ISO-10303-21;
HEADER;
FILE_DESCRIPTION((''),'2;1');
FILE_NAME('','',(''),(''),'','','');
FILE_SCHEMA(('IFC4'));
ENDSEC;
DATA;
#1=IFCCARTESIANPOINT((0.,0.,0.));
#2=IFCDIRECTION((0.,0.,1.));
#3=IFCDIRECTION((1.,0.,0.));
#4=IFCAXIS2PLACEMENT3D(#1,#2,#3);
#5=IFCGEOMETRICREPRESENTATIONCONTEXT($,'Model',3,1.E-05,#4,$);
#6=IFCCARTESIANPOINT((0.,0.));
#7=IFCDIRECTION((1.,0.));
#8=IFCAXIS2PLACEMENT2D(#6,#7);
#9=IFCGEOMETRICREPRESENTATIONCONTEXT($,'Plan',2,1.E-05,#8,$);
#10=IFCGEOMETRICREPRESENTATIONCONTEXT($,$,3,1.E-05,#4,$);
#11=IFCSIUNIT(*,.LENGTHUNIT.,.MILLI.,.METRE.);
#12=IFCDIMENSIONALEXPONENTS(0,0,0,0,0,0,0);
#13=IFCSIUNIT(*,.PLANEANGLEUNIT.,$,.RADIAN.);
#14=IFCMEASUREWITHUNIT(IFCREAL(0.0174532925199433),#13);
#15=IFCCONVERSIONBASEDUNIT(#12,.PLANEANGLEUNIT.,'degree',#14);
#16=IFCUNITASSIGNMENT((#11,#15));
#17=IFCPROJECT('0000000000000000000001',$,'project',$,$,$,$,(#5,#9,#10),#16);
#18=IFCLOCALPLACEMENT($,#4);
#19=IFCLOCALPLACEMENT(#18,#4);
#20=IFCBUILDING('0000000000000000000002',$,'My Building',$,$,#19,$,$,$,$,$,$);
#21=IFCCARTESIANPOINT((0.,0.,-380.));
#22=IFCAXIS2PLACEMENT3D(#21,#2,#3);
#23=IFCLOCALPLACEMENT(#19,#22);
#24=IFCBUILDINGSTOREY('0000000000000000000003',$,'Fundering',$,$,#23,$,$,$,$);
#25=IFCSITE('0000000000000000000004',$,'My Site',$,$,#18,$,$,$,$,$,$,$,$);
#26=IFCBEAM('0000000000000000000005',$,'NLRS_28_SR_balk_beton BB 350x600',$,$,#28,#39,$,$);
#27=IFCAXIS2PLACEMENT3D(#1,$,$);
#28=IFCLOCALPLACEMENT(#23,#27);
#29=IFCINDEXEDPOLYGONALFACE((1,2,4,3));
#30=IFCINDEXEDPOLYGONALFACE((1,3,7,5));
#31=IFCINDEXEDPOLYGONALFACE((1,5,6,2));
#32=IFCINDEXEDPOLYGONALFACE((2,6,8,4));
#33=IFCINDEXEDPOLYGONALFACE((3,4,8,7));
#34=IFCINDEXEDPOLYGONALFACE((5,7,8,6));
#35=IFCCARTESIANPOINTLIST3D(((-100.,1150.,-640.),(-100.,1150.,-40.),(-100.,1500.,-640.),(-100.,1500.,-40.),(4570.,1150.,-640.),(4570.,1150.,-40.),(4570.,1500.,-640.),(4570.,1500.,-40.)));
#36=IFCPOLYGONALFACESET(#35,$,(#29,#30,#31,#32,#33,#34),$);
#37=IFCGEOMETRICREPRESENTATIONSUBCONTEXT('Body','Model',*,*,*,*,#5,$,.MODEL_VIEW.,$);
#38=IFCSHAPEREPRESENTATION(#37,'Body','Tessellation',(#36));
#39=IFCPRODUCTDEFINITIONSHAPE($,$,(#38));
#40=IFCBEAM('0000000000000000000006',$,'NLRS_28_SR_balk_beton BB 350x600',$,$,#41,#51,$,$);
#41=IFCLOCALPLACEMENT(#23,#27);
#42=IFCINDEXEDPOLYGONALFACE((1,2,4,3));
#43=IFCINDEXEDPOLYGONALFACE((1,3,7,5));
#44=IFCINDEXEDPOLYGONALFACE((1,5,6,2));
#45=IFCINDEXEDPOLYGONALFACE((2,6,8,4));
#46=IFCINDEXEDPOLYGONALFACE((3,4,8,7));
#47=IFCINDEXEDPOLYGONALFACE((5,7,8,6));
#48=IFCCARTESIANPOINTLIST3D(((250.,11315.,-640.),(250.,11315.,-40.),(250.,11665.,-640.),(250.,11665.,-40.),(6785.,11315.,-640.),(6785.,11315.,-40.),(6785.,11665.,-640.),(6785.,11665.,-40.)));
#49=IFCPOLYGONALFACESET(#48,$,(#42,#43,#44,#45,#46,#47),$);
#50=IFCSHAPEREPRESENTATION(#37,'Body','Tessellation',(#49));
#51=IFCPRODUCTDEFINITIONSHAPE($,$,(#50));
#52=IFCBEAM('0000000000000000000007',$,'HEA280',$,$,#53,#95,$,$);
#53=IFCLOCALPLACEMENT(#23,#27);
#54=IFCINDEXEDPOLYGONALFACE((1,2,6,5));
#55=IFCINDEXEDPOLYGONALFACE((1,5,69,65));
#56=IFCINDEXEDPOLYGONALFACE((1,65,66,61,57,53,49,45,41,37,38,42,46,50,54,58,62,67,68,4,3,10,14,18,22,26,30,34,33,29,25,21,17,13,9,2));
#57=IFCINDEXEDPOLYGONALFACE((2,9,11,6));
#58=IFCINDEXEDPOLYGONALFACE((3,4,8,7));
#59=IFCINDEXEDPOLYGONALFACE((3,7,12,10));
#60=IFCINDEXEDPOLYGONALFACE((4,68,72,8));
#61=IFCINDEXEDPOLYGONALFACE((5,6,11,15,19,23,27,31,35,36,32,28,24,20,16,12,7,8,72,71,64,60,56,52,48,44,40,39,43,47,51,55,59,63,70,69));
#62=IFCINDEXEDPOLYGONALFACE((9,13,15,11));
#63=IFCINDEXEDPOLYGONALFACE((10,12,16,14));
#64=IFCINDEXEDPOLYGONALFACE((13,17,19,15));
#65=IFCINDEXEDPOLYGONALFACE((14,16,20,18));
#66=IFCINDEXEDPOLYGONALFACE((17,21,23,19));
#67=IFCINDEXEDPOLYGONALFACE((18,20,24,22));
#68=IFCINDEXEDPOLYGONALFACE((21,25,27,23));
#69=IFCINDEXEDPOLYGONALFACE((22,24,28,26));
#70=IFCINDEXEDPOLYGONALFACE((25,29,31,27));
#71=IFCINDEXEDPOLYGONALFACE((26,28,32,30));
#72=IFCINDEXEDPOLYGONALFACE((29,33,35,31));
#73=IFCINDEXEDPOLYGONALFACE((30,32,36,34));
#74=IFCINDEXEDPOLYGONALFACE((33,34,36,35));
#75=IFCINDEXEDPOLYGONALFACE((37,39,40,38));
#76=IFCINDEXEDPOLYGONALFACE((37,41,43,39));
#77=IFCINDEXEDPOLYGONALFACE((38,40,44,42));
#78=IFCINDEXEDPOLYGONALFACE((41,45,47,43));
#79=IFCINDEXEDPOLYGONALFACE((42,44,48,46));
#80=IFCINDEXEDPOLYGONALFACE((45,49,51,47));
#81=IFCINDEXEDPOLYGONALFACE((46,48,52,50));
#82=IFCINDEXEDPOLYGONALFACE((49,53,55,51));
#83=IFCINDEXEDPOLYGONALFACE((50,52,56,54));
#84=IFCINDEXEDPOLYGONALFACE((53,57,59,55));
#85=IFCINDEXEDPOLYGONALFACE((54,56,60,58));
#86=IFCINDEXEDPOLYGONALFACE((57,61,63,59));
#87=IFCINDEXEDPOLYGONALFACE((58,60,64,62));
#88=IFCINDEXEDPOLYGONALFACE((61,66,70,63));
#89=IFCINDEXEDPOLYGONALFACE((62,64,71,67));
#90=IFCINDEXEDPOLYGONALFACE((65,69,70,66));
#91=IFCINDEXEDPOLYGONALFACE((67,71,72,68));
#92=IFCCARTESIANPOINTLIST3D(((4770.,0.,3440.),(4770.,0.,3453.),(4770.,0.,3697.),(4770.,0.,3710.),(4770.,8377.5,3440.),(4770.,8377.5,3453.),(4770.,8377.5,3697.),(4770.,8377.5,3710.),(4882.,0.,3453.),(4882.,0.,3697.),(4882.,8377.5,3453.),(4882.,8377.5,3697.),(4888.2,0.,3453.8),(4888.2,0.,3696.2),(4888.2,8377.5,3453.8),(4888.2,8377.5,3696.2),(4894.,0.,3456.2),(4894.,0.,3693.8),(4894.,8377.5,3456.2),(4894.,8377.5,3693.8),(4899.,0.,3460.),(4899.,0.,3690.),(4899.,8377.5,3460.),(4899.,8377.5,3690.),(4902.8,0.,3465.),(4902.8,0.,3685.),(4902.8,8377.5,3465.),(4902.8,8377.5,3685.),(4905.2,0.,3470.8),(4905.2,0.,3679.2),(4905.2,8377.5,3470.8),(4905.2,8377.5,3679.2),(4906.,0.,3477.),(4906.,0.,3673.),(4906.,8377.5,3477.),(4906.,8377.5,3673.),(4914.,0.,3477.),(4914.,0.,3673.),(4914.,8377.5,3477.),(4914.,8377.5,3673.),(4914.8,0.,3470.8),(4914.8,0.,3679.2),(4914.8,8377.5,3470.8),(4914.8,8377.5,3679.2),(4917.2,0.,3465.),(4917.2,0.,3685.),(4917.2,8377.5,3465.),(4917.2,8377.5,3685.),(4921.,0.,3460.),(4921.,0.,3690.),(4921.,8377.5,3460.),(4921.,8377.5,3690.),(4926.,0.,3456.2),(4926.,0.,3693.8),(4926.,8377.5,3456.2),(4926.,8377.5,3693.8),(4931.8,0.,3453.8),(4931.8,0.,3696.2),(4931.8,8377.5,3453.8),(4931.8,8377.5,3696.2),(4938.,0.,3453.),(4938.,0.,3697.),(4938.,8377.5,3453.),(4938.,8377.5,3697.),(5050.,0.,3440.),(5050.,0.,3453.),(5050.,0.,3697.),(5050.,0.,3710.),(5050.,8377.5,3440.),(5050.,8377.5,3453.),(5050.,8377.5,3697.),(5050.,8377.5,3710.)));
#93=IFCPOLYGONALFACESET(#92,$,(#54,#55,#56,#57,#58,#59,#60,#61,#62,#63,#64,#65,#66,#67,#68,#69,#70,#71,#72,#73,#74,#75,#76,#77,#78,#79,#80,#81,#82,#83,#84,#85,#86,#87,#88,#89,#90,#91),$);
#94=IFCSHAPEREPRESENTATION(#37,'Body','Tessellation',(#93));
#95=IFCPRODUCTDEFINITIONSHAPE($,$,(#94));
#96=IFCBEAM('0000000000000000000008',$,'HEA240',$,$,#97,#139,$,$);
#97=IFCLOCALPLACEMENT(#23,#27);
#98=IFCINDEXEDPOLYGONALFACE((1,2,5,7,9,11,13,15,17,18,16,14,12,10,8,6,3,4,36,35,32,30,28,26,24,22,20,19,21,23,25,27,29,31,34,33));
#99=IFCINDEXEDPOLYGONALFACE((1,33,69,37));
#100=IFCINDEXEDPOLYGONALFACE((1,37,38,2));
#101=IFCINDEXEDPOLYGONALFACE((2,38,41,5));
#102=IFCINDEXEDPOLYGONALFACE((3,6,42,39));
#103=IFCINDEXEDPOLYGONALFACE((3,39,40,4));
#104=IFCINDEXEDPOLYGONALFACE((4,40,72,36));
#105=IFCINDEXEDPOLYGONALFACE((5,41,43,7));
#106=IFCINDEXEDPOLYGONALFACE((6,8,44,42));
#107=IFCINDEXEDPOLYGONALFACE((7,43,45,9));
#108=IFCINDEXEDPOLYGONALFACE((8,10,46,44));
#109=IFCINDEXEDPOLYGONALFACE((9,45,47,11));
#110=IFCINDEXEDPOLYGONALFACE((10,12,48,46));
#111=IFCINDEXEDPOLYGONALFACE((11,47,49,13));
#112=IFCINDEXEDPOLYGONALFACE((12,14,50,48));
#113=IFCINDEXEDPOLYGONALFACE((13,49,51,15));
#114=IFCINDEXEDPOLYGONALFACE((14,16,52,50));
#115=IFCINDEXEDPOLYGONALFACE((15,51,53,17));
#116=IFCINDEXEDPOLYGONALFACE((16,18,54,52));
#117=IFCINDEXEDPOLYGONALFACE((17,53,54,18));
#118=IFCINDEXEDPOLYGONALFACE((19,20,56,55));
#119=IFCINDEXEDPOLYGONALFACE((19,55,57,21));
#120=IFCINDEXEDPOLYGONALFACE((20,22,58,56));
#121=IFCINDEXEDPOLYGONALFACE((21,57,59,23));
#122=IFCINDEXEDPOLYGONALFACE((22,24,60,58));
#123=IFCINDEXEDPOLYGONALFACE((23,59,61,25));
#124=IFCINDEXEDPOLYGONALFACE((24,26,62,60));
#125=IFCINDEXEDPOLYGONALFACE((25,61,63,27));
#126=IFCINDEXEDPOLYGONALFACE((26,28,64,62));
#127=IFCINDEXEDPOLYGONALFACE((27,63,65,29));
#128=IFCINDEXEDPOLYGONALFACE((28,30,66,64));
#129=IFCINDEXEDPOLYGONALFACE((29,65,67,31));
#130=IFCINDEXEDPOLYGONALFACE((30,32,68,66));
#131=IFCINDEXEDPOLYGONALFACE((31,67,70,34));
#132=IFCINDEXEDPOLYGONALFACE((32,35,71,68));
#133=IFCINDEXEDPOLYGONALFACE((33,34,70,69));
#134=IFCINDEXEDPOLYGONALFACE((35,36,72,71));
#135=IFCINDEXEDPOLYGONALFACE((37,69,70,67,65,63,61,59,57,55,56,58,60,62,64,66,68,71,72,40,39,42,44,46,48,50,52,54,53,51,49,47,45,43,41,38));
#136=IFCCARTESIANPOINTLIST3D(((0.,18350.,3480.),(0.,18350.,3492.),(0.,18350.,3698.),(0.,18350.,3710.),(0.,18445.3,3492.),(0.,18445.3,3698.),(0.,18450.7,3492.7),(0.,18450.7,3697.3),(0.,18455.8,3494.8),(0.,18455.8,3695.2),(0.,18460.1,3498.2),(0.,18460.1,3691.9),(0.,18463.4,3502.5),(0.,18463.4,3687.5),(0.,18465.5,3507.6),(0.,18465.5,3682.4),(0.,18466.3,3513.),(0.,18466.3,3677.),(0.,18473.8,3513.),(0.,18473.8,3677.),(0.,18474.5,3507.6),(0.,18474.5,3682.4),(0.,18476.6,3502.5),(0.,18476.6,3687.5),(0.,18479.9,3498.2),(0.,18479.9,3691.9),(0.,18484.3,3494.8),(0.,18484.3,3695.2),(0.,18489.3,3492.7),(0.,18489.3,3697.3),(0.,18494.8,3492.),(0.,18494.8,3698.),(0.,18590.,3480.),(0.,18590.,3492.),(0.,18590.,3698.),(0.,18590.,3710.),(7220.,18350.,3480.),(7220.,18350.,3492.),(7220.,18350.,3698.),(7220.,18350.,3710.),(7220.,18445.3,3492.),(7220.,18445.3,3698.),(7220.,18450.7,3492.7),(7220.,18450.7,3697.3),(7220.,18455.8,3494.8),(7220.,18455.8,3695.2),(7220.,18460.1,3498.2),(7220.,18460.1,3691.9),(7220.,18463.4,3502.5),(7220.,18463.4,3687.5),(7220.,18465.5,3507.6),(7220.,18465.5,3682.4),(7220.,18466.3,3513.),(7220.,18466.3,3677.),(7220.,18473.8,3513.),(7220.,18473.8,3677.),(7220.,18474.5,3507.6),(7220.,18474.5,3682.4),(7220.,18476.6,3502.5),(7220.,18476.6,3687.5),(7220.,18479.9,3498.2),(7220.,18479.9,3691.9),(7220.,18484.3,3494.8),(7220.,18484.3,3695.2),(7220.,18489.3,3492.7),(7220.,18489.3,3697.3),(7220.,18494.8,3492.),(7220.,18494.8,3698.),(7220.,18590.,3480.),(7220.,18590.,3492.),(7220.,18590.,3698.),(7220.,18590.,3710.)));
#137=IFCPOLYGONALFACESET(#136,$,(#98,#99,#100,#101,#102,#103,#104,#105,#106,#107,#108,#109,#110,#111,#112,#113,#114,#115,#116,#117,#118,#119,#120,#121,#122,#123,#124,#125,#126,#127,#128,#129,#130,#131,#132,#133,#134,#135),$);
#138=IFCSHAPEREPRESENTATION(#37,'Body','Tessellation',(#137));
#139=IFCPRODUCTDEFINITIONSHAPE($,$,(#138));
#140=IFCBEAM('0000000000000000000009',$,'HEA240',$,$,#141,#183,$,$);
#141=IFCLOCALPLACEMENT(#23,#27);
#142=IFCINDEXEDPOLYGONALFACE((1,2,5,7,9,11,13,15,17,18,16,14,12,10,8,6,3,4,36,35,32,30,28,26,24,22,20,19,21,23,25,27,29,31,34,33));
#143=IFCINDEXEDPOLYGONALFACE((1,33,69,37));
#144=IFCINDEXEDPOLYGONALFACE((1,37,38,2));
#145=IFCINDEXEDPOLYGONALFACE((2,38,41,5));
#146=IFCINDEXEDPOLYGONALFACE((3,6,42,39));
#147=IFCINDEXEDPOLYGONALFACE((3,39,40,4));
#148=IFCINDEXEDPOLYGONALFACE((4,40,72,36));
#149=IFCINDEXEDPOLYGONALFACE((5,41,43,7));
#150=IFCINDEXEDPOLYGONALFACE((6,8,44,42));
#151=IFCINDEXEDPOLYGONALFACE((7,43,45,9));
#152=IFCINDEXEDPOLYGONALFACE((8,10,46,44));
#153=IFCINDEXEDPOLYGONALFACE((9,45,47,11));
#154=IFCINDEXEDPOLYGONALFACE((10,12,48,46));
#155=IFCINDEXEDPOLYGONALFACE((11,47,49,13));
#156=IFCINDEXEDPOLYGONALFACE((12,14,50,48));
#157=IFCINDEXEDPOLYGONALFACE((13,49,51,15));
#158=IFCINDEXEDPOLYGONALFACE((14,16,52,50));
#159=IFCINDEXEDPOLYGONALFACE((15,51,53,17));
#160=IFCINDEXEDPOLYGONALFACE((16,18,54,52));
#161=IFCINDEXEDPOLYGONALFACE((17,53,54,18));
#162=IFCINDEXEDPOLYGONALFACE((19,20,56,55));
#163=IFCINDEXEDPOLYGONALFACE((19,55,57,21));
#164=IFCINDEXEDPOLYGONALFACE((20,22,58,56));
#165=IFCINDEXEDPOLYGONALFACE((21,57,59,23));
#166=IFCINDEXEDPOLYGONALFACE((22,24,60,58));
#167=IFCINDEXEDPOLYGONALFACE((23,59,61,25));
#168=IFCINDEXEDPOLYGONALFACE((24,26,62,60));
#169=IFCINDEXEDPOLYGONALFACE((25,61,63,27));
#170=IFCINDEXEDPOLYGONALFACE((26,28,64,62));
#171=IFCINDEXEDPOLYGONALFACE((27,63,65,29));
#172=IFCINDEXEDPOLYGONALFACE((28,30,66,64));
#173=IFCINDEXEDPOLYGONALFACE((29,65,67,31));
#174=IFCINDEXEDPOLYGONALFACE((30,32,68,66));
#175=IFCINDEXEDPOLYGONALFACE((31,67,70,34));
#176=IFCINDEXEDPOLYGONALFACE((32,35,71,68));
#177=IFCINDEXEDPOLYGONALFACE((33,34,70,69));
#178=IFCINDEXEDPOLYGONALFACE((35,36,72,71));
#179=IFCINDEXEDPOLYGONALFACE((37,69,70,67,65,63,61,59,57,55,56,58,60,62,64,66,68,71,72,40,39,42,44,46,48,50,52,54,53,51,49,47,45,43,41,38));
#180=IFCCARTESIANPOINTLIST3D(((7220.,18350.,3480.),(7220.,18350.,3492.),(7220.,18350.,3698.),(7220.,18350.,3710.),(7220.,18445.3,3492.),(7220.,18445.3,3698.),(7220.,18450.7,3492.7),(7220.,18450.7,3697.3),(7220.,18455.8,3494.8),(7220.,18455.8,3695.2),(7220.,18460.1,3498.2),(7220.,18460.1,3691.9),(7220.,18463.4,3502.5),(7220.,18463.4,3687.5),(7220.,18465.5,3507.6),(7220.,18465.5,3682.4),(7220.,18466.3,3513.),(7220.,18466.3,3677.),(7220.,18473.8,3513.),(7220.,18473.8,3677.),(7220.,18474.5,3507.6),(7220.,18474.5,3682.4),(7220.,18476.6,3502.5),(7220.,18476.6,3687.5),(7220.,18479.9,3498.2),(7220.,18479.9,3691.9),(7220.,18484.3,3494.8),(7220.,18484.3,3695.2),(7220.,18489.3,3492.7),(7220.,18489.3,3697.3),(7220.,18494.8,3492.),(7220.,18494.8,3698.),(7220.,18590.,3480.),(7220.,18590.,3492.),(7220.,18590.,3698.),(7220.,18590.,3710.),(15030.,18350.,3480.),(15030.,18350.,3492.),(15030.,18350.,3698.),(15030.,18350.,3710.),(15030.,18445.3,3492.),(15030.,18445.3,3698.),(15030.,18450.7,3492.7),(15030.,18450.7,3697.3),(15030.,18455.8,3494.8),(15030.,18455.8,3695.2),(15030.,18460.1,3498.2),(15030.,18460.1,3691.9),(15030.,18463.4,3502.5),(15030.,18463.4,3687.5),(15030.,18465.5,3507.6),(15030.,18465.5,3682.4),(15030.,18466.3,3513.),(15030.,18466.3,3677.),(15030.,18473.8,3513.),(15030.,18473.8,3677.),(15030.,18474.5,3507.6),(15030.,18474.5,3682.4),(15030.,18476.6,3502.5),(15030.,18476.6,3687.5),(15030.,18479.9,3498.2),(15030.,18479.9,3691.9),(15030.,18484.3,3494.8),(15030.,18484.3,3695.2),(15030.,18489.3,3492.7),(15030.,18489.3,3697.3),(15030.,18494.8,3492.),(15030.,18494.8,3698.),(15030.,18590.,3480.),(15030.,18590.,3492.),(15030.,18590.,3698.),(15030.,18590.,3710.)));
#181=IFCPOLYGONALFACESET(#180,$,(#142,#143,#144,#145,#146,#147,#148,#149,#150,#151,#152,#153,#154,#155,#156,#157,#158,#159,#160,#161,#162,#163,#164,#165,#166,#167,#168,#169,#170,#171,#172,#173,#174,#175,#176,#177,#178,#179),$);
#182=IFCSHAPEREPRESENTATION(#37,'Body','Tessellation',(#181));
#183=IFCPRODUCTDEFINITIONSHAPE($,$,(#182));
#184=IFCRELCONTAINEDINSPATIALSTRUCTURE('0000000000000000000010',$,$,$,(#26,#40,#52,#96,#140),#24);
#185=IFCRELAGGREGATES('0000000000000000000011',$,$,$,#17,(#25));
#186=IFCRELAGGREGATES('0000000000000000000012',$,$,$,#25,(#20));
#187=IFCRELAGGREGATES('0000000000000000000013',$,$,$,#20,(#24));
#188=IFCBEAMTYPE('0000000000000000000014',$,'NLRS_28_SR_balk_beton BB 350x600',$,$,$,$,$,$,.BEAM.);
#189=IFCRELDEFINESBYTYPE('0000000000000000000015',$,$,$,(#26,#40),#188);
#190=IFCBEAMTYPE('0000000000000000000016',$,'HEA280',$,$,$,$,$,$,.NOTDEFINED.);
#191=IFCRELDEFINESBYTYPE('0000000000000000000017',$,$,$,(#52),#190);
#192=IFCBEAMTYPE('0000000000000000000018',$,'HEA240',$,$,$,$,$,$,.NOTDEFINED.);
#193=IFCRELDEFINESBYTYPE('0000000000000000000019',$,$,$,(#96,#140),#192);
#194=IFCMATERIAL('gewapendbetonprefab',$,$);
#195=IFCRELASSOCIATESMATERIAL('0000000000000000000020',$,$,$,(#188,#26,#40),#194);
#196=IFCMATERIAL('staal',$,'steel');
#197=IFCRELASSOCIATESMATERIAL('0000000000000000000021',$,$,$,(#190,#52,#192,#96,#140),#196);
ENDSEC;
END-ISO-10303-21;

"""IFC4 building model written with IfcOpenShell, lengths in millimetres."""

from ifc_helpers import new_model, entity, si_unit, converted_unit, frame, origin_with_axes, origin_2d_with_axis, place, context, subcontext, project, spatial, rectangle, i_section, extrude, material, material_profile, profile_set, profile_usage, type_object, element, save


model = new_model("IFC4")

# Units and contexts
model_context = context("Model", 3, precision=1e-05, world=origin_with_axes())
plan_context = context("Plan", 2, precision=1e-05, world=origin_2d_with_axis())
context_of_model = context(None, 3, precision=1e-05, world=origin_with_axes())
body_context = subcontext(model_context, "Body", "Model", "MODEL_VIEW")
ifc_project = project(units=[si_unit("LENGTHUNIT", "METRE", prefix="MILLI"), converted_unit("PLANEANGLEUNIT", "degree", entity("IfcReal", 0.0174532925199433), si_unit("PLANEANGLEUNIT", "RADIAN"), dimensions=[0, 0, 0, 0, 0, 0, 0])], contexts=[model_context, plan_context, context_of_model])

# Site, building, storey
site_placement = place(None, origin_with_axes())
site = spatial("IfcSite", under=ifc_project, at=site_placement, Name="My Site")
building_placement = place(site_placement, origin_with_axes())
building = spatial("IfcBuilding", under=site, at=building_placement, Name="My Building")
storey_placement = place(building_placement, frame((0.0, 0.0, -380.0), z_axis=(0.0, 0.0, 1.0), x_axis=(1.0, 0.0, 0.0)))
storey = spatial("IfcBuildingStorey", under=building, at=storey_placement, Name="Fundering")

# Shared definitions
ifc_material_1 = material(Name="staal", Category="steel")

# Beams
ifc_material_2 = material(Name="gewapendbetonprefab")
ifc_material_profile_1 = material_profile(ifc_material_2, rectangle(XDim=350.0, YDim=600.0))
ifc_profile_set_1 = profile_set([ifc_material_profile_1], Name="NLRS_28_SR_balk_beton BB 350x600")
beam_type_1 = type_object("IfcBeamType", Name="NLRS_28_SR_balk_beton BB 350x600", PredefinedType="BEAM", material=ifc_profile_set_1)
ifc_profile_usage_1 = profile_usage(ifc_profile_set_1, cardinal=8)
beam_1_placement = place(storey_placement, frame((4570.0, 1325.0, -40.0), z_axis=(-1.0, 0.0, 0.0), x_axis=(0.0, -1.0, 0.0)))
element("IfcBeam", 1, at=beam_1_placement, inside=storey, type_object=beam_type_1, material=ifc_profile_usage_1, Name="NLRS_28_SR_balk_beton BB 350x600", context=body_context, shape_type="SweptSolid", body=[
    extrude(rectangle(XDim=350.0, YDim=600.0), frame((0.0, -300.0, 0.0), z_axis=(0.0, 0.0, 1.0), x_axis=(1.0, 0.0, 0.0)), (0.0, 0.0, 1.0), 4670.0),
])
ifc_profile_usage_2 = profile_usage(ifc_profile_set_1, cardinal=8)
beam_2_placement = place(storey_placement, frame((6785.0, 11490.0, -40.0), z_axis=(-1.0, 0.0, 0.0), x_axis=(0.0, -1.0, 0.0)))
element("IfcBeam", 2, at=beam_2_placement, inside=storey, type_object=beam_type_1, material=ifc_profile_usage_2, Name="NLRS_28_SR_balk_beton BB 350x600", context=body_context, shape_type="SweptSolid", body=[
    extrude(rectangle(XDim=350.0, YDim=600.0), frame((0.0, -300.0, 0.0), z_axis=(0.0, 0.0, 1.0), x_axis=(1.0, 0.0, 0.0)), (0.0, 0.0, 1.0), 6535.0),
])
ifc_material_profile_2 = material_profile(ifc_material_1, i_section(OverallWidth=280.0, OverallDepth=270.0, WebThickness=8.0, FlangeThickness=13.0, FilletRadius=24.0))
ifc_profile_set_2 = profile_set([ifc_material_profile_2], Name="HEA280")
ifc_profile_usage_3 = profile_usage(ifc_profile_set_2)
beam_type_2 = type_object("IfcBeamType", Name="HEA280", PredefinedType="NOTDEFINED", material=ifc_profile_set_2)
beam_3_placement = place(storey_placement, frame((4910.0, 0.0, 3575.0), z_axis=(0.0, 1.0, 0.0), x_axis=(-1.0, 0.0, 0.0)))
element("IfcBeam", 3, at=beam_3_placement, inside=storey, type_object=beam_type_2, material=ifc_profile_usage_3, Name="HEA280", context=body_context, shape_type="SweptSolid", body=[
    extrude(i_section(OverallWidth=280.0, OverallDepth=270.0, WebThickness=8.0, FlangeThickness=13.0, FilletRadius=24.0), origin_with_axes(), (0.0, 0.0, 1.0), 8377.5),
])
ifc_material_profile_3 = material_profile(ifc_material_1, i_section(OverallWidth=240.0, OverallDepth=230.0, WebThickness=7.5, FlangeThickness=12.0, FilletRadius=21.0))
ifc_profile_set_3 = profile_set([ifc_material_profile_3], Name="HEA240")
ifc_profile_usage_4 = profile_usage(ifc_profile_set_3, cardinal=5)
beam_type_3 = type_object("IfcBeamType", Name="HEA240", PredefinedType="NOTDEFINED", material=ifc_profile_set_3)
beam_4_placement = place(storey_placement, frame((0.0, 18470.0, 3595.0), z_axis=(1.0, 0.0, 0.0), x_axis=(0.0, 1.0, 0.0)))
element("IfcBeam", 4, at=beam_4_placement, inside=storey, type_object=beam_type_3, material=ifc_profile_usage_4, Name="HEA240", context=body_context, shape_type="SweptSolid", body=[
    extrude(i_section(OverallWidth=240.0, OverallDepth=230.0, WebThickness=7.5, FlangeThickness=12.0, FilletRadius=21.0), origin_with_axes(), (0.0, 0.0, 1.0), 7220.0),
])
ifc_profile_usage_5 = profile_usage(ifc_profile_set_3, cardinal=5)
beam_5_placement = place(storey_placement, frame((7220.0, 18470.0, 3595.0), z_axis=(1.0, 0.0, 0.0), x_axis=(0.0, 1.0, 0.0)))
element("IfcBeam", 5, at=beam_5_placement, inside=storey, type_object=beam_type_3, material=ifc_profile_usage_5, Name="HEA240", context=body_context, shape_type="SweptSolid", body=[
    extrude(i_section(OverallWidth=240.0, OverallDepth=230.0, WebThickness=7.5, FlangeThickness=12.0, FilletRadius=21.0), origin_with_axes(), (0.0, 0.0, 1.0), 7810.0),
])

save(model, "model.ifc")
